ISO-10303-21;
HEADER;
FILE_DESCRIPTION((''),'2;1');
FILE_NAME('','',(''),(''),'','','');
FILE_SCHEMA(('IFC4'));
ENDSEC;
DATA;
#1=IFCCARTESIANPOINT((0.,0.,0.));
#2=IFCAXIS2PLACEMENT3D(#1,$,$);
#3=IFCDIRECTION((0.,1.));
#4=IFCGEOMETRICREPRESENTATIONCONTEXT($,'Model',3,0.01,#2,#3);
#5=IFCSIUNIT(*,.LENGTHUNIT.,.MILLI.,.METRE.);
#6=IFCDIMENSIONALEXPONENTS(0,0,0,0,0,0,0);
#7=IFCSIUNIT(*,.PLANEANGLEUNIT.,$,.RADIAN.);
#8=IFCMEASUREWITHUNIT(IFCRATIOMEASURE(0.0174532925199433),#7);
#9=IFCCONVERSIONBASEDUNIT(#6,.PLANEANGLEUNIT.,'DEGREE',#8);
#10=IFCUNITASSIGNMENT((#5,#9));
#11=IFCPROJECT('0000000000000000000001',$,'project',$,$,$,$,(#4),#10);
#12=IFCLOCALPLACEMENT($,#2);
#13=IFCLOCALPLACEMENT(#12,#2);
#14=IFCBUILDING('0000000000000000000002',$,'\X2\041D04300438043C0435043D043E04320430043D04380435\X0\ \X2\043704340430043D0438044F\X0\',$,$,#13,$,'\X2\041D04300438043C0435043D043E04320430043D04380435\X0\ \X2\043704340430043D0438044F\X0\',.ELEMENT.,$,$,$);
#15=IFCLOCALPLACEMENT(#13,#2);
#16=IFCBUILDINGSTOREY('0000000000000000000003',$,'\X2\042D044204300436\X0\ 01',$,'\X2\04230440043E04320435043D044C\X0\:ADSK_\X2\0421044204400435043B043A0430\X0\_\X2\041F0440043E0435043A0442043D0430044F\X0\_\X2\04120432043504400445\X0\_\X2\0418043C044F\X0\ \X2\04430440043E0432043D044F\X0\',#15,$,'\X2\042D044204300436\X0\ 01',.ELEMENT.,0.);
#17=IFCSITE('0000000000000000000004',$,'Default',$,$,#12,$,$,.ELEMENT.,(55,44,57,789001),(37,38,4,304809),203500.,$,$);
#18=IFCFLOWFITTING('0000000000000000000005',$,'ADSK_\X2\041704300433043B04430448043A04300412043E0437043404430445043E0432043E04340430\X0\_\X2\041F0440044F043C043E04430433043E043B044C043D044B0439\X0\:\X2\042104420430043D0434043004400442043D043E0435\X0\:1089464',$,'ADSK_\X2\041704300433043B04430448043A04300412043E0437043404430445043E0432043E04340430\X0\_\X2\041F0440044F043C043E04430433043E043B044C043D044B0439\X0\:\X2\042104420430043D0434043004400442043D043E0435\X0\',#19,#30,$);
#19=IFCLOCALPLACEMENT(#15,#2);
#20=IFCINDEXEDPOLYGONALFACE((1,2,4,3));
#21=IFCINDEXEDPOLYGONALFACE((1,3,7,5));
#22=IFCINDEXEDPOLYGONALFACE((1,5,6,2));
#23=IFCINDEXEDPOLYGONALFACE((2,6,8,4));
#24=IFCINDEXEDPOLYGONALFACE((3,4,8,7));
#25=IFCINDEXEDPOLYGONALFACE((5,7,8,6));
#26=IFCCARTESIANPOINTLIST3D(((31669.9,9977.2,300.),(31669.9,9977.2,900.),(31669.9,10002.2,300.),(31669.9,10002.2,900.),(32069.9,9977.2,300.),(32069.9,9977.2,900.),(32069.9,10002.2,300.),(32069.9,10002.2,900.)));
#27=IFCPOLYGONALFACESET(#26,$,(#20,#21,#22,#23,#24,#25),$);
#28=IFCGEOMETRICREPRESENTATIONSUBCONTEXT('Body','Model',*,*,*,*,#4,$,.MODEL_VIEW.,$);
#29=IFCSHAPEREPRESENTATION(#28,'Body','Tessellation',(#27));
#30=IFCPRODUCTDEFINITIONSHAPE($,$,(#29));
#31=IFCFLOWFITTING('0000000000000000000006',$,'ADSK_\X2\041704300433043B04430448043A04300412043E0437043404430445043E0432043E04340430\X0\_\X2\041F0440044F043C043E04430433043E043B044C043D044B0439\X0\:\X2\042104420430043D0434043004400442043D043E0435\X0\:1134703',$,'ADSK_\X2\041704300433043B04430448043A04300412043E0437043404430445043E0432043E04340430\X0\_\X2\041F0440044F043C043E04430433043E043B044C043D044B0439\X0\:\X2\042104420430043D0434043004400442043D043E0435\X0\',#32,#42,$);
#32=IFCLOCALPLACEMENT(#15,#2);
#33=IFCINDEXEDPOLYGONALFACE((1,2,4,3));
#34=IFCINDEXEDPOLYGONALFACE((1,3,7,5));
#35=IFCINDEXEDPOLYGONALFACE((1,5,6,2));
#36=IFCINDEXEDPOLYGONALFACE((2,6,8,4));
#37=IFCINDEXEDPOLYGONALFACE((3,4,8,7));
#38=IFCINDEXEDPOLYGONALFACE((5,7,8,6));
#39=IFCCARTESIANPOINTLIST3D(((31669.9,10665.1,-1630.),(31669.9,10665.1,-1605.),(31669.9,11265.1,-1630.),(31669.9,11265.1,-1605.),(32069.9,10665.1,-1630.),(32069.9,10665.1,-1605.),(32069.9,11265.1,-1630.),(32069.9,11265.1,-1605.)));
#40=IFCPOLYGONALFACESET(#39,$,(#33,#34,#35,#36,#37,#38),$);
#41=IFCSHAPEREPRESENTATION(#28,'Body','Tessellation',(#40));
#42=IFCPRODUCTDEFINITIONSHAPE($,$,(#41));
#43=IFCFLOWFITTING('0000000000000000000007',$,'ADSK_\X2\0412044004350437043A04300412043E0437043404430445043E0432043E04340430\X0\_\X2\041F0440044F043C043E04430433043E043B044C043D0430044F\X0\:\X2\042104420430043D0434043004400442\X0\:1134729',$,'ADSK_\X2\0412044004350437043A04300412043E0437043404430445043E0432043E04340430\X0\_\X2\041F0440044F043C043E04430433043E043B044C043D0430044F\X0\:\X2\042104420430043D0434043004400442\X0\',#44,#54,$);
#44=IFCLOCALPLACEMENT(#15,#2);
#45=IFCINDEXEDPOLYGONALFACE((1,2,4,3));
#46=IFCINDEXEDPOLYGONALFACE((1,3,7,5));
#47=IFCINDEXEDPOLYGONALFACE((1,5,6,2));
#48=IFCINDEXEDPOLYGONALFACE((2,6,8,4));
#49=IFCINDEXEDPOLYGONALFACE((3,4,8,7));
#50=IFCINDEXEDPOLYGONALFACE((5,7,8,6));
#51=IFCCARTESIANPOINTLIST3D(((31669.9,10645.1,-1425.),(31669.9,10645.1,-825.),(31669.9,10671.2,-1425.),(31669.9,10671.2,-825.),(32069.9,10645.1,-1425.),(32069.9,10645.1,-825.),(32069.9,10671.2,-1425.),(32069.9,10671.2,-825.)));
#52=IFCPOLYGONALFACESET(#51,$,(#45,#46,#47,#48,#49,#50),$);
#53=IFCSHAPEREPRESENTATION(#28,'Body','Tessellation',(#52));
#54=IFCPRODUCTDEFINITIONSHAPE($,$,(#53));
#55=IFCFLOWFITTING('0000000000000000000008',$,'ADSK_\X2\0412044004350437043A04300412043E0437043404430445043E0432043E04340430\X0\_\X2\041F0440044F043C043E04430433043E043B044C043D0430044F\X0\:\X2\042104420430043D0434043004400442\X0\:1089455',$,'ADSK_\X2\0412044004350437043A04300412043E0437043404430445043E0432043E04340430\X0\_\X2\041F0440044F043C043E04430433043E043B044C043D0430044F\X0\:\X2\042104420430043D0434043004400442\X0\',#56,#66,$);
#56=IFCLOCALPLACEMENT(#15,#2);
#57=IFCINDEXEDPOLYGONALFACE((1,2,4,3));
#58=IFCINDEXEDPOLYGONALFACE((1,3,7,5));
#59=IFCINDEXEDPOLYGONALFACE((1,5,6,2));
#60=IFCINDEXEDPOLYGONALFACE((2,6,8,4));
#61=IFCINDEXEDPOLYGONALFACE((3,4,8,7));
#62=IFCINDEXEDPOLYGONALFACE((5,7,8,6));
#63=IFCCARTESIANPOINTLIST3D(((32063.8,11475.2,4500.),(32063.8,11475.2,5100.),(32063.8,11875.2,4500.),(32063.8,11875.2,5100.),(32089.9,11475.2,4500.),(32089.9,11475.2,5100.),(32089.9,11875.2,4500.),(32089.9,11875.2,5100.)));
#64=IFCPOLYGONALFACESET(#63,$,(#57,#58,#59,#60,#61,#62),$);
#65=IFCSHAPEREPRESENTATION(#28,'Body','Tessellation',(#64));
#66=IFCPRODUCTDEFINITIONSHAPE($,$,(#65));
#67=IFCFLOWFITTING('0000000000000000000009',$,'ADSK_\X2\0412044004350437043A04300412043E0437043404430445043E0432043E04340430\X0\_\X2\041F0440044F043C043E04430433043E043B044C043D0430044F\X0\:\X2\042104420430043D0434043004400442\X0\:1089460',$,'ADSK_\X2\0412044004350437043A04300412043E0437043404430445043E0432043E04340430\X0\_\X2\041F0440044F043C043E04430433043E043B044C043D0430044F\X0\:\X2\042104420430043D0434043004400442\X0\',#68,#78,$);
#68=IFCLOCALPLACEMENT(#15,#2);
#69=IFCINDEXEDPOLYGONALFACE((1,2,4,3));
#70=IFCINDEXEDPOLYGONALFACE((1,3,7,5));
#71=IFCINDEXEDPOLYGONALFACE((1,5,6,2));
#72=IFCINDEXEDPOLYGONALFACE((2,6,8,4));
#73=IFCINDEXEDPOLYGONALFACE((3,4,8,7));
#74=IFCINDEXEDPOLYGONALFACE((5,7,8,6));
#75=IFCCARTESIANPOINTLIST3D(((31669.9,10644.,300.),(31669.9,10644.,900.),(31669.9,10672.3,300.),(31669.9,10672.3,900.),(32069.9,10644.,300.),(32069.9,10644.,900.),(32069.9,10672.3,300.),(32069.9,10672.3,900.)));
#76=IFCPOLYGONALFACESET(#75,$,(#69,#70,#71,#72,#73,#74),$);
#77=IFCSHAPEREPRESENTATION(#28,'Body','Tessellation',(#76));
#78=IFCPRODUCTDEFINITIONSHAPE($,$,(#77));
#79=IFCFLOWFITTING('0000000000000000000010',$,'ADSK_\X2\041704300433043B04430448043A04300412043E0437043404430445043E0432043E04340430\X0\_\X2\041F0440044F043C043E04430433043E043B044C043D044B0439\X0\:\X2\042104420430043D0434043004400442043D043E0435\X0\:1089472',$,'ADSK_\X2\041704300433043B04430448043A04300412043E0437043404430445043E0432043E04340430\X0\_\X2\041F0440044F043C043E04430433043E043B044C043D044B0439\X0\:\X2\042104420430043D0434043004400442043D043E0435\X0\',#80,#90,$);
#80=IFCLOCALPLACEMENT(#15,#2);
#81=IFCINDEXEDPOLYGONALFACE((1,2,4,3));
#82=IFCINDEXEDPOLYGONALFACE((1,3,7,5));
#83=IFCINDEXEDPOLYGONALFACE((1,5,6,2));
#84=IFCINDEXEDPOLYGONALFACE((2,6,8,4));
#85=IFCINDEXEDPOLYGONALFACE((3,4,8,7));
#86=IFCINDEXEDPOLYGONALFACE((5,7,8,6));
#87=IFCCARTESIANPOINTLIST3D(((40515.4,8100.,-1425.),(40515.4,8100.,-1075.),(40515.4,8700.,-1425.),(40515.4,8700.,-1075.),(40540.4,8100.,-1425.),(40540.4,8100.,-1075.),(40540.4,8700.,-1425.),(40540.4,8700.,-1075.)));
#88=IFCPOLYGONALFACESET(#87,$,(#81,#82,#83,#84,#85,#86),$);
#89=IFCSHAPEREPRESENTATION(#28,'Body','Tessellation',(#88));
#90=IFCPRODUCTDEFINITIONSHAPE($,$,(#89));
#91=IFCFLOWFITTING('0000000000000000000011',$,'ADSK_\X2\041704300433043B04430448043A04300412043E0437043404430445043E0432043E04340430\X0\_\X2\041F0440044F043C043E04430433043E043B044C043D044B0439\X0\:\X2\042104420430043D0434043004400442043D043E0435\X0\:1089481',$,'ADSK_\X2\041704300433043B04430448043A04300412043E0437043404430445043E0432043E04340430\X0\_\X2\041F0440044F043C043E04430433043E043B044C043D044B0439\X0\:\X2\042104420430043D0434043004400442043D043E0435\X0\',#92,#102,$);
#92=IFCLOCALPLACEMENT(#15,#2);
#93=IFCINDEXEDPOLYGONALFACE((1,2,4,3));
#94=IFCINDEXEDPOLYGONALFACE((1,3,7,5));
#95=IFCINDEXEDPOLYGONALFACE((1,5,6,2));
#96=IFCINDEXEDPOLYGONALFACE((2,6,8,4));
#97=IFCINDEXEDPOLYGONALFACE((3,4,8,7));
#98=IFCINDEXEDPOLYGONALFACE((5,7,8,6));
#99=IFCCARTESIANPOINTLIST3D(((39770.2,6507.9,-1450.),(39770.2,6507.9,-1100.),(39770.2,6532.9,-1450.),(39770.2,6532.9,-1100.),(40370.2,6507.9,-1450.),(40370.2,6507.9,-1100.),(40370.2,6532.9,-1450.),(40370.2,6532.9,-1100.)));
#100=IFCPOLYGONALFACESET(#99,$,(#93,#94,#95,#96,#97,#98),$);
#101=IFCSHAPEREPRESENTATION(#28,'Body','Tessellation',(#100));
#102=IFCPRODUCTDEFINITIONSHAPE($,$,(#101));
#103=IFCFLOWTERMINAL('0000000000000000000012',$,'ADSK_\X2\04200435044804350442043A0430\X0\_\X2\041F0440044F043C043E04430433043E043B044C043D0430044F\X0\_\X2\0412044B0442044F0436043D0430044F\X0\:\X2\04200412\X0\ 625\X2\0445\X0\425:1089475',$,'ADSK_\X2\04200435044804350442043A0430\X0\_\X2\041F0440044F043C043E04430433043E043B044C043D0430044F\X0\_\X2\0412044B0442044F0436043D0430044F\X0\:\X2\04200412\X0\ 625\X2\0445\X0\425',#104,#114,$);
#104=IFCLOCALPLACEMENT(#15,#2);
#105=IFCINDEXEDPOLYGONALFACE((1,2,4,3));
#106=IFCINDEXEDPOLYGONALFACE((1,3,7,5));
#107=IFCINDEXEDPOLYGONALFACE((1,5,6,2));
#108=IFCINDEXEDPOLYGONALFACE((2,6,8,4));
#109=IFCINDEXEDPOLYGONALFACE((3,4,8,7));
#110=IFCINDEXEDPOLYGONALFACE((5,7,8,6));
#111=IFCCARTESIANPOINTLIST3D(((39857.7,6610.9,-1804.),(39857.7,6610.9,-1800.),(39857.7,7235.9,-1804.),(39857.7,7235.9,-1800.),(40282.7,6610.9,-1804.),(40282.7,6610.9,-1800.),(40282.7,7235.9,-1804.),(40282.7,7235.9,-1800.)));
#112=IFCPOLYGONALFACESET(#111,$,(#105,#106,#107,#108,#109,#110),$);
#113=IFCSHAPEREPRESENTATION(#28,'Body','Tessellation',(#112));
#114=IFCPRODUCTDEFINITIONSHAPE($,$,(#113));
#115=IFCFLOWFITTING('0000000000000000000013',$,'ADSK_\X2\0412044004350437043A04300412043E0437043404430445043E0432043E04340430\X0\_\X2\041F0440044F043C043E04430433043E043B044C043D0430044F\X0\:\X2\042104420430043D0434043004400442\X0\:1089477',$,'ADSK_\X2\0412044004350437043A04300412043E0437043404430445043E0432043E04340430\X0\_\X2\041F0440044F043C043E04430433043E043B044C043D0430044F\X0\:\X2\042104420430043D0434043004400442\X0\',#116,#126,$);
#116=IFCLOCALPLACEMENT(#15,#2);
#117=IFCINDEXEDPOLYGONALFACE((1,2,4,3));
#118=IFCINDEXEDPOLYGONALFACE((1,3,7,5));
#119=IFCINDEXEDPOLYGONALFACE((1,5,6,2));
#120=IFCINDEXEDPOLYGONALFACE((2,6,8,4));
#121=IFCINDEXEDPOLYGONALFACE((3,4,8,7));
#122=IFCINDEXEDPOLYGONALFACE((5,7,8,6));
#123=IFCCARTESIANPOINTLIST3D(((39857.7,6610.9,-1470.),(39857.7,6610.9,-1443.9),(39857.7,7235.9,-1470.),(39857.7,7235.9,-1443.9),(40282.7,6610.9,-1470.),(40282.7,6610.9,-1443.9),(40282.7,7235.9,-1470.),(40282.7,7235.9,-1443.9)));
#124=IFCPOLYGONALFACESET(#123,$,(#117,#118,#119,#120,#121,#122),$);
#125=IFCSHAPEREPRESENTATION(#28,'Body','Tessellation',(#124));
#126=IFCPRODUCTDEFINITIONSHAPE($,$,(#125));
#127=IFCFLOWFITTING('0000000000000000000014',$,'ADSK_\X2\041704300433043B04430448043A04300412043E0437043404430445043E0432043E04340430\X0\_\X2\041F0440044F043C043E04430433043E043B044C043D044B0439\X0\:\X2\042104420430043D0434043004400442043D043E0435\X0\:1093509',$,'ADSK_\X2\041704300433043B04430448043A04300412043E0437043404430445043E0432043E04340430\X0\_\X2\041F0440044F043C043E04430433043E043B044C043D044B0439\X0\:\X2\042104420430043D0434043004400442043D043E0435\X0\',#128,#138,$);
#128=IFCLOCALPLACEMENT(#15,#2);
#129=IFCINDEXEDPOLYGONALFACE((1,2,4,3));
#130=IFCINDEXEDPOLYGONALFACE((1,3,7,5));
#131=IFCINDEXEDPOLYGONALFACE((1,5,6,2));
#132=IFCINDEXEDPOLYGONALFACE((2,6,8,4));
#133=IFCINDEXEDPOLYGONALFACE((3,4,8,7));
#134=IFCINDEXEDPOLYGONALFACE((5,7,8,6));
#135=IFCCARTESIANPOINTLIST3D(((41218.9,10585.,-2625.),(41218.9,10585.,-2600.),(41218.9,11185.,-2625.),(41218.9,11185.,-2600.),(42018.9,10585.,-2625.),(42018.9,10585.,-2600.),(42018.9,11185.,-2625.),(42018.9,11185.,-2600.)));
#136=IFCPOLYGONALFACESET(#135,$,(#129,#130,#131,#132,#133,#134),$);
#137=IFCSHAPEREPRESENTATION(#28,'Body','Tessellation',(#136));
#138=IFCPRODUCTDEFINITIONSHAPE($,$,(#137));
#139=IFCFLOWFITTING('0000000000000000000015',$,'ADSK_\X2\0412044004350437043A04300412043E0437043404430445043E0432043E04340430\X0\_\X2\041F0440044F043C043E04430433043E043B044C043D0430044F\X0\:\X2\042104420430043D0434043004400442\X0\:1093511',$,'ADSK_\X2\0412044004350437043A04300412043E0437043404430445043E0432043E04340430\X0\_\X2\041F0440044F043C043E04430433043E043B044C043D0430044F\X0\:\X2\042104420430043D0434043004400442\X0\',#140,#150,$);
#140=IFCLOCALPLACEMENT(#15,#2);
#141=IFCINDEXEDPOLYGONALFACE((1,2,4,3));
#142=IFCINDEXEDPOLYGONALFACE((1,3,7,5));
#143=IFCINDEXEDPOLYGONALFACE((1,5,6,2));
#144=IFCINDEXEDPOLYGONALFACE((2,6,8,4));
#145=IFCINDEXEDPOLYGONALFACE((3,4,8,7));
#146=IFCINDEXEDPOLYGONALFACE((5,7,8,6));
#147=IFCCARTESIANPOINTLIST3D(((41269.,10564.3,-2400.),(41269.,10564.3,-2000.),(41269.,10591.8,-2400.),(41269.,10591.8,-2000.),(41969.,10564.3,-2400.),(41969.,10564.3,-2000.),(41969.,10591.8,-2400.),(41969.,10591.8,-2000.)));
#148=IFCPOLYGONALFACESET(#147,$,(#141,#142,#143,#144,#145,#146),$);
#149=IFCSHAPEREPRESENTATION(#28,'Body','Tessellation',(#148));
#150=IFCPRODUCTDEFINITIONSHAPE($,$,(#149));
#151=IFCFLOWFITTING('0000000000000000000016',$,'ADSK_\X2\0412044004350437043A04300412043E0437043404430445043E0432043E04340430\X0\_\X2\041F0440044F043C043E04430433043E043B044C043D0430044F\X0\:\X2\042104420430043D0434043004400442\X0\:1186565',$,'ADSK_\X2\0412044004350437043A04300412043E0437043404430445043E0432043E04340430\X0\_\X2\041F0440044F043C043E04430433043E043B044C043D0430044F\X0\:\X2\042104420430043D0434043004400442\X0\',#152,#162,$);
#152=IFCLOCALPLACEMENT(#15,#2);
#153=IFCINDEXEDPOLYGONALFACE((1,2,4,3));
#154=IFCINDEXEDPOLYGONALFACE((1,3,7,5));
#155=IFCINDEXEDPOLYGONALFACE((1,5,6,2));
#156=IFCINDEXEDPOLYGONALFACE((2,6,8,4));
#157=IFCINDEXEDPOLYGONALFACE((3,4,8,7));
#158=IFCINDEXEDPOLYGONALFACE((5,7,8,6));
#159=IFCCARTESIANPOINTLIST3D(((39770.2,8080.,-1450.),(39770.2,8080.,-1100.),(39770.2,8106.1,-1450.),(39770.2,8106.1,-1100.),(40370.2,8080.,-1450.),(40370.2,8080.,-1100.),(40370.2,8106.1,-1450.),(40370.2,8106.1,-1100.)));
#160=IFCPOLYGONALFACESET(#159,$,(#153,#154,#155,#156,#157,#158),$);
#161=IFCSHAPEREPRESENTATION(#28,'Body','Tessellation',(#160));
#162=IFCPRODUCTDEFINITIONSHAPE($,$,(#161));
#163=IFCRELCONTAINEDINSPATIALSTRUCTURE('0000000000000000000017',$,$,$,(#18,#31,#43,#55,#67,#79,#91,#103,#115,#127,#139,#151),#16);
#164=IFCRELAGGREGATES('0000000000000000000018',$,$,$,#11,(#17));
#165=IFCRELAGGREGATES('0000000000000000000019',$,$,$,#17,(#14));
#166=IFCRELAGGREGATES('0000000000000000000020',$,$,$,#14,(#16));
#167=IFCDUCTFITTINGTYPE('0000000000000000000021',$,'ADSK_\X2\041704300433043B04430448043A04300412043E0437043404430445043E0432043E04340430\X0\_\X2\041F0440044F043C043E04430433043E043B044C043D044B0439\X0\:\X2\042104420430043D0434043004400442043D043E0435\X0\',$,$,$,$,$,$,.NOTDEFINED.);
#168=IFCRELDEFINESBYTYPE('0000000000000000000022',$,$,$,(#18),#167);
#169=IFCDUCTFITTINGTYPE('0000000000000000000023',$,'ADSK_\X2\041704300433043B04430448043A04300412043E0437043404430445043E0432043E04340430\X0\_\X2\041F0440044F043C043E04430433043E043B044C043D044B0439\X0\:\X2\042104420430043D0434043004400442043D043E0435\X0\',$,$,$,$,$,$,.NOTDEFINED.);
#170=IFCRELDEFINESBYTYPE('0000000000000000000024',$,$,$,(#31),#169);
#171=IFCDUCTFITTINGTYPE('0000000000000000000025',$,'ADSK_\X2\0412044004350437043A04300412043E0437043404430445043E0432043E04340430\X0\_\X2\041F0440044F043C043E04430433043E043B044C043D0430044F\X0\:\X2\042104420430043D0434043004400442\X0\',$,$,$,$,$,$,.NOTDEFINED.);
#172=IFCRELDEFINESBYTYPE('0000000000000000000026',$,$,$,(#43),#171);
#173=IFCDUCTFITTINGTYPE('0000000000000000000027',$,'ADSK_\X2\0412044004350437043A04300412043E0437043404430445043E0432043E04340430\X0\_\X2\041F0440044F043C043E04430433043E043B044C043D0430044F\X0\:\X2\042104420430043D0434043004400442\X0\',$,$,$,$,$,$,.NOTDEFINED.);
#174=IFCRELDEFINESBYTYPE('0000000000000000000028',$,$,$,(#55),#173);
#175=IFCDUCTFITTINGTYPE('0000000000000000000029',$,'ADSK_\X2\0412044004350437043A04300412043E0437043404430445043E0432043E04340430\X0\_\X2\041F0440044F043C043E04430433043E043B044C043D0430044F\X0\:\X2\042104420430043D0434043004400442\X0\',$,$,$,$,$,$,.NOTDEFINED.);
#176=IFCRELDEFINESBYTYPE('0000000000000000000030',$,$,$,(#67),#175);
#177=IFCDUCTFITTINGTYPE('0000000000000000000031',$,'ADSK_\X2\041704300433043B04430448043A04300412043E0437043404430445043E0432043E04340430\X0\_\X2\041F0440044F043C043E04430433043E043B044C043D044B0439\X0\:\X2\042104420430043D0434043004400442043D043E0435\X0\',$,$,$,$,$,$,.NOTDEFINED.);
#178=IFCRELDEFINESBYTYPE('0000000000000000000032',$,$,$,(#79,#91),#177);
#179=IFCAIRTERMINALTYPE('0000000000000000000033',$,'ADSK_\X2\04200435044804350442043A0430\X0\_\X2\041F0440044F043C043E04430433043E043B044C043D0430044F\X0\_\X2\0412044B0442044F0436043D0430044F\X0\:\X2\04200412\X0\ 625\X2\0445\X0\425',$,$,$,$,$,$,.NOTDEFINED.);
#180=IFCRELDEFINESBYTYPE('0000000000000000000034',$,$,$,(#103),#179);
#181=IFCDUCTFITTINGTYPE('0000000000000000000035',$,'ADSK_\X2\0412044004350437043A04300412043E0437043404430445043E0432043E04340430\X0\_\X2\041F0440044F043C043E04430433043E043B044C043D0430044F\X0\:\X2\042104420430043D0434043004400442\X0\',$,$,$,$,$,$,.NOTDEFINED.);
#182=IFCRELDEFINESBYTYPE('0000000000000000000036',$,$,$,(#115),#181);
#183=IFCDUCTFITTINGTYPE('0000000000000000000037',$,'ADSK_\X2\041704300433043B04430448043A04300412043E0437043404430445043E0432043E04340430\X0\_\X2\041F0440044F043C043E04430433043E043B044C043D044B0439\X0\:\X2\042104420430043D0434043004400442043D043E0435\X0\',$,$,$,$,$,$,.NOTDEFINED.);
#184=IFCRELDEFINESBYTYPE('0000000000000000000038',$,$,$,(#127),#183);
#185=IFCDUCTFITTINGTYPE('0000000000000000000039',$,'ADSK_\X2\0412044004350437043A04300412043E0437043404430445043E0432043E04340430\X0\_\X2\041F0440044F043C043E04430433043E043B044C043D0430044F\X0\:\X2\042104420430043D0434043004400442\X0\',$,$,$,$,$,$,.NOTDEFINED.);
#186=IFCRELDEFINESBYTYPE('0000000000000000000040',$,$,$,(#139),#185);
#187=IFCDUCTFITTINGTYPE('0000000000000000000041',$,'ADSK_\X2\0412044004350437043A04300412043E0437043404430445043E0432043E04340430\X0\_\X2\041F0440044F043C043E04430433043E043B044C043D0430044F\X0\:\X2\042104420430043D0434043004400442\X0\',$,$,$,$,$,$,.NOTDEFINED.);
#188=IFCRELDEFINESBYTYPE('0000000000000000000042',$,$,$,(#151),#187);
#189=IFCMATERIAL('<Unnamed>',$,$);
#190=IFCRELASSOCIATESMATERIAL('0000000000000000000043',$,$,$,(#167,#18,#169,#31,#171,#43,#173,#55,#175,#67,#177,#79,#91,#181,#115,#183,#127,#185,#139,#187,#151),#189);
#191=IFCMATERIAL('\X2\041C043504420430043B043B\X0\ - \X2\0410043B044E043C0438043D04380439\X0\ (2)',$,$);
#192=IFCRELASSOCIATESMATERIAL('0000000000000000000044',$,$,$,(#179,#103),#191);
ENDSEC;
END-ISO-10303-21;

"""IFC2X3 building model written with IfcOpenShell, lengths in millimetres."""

from ifc_helpers import new_model, entity, si_unit, converted_unit, direction, frame, origin, origin_2d_with_axis, place, context, subcontext, project, spatial, rectangle, extrude, source, transform, mapped, material, type_object, type_shapes, element, save


model = new_model("IFC2X3")

# Units and contexts
model_context = context("Model", 3, precision=0.01, world=origin(), true_north=direction((0.0, 1.0)))
body_context = subcontext(model_context, "Body", "Model", "MODEL_VIEW")
ifc_project = project(units=[si_unit("LENGTHUNIT", "METRE", prefix="MILLI"), converted_unit("PLANEANGLEUNIT", "DEGREE", entity("IfcRatioMeasure", 0.0174532925199433), si_unit("PLANEANGLEUNIT", "RADIAN"), dimensions=[0, 0, 0, 0, 0, 0, 0])], contexts=[model_context])

# Site, building, storey
site_placement = place(None, origin())
site = spatial("IfcSite", under=ifc_project, at=site_placement, Name="Default", CompositionType="ELEMENT", RefLatitude=(55, 44, 57, 789001), RefLongitude=(37, 38, 4, 304809), RefElevation=203500.0)
building_placement = place(site_placement, origin())
building = spatial("IfcBuilding", under=site, at=building_placement, Name="Наименование здания", LongName="Наименование здания", CompositionType="ELEMENT")
storey_placement = place(building_placement, origin())
storey = spatial("IfcBuildingStorey", under=building, at=storey_placement, Name="Этаж 01", ObjectType="Уровень:ADSK_Стрелка_Проектная_Вверх_Имя уровня", LongName="Этаж 01", CompositionType="ELEMENT", Elevation=0.0)

# Flow fittings
ifc_material_1 = material(Name="<Unnamed>")
duct_fitting_type_1 = type_object("IfcDuctFittingType", Name="ADSK_ЗаглушкаВоздуховода_Прямоугольный:Стандартное", PredefinedType="NOTDEFINED", material=ifc_material_1)
shared_shape_1 = source(origin(), body_context, "Body", "SweptSolid", [
    extrude(rectangle(XDim=25.0, YDim=400.0, at=origin_2d_with_axis()), frame((12.5, 0.0, -300.0)), (0.0, 0.0, 1.0), 600.0),
])
type_shapes(duct_fitting_type_1, [shared_shape_1])
for number, where, z_axis, x_axis, name in (
    (1, (31869.9, 10002.2, 600.0), (0.0, 0.0, 1.0), (0.0, -1.0, 0.0), "ADSK_ЗаглушкаВоздуховода_Прямоугольный:Стандартное:1089464"),
):
    element("IfcFlowFitting", number, at=place(storey_placement, frame(where, z_axis=z_axis, x_axis=x_axis)), inside=storey, type_object=duct_fitting_type_1, material=ifc_material_1, Name=name, ObjectType="ADSK_ЗаглушкаВоздуховода_Прямоугольный:Стандартное", context=body_context, shape_type="MappedRepresentation", body=[
        mapped(shared_shape_1, transform((0.0, 0.0, 0.0), scale=1.0)),
    ])
duct_fitting_type_2 = type_object("IfcDuctFittingType", Name="ADSK_ЗаглушкаВоздуховода_Прямоугольный:Стандартное", PredefinedType="NOTDEFINED", material=ifc_material_1)
shared_shape_2 = source(origin(), body_context, "Body", "SweptSolid", [
    extrude(rectangle(XDim=25.0, YDim=600.0, at=origin_2d_with_axis()), frame((12.5, 0.0, -200.0)), (0.0, 0.0, 1.0), 400.0),
])
type_shapes(duct_fitting_type_2, [shared_shape_2])
flow_fitting_1_placement = place(storey_placement, frame((31869.9, 10965.1, -1605.0), z_axis=(1.0, 0.0, 0.0), x_axis=(0.0, 0.0, -1.0)))
element("IfcFlowFitting", 2, at=flow_fitting_1_placement, inside=storey, type_object=duct_fitting_type_2, material=ifc_material_1, Name="ADSK_ЗаглушкаВоздуховода_Прямоугольный:Стандартное:1134703", ObjectType="ADSK_ЗаглушкаВоздуховода_Прямоугольный:Стандартное", context=body_context, shape_type="MappedRepresentation", body=[
    mapped(shared_shape_2, transform((0.0, 0.0, 0.0), scale=1.0)),
])
duct_fitting_type_3 = type_object("IfcDuctFittingType", Name="ADSK_ВрезкаВоздуховода_Прямоугольная:Стандарт", PredefinedType="NOTDEFINED", material=ifc_material_1)
shared_shape_3 = source(origin(), body_context, "Body", "SweptSolid", [
    extrude(rectangle(XDim=600.0, YDim=26.1, at=origin_2d_with_axis()), frame((7.0, 0.0, -200.0), z_axis=(0.0, 0.0, 1.0), x_axis=(0.0, -1.0, 0.0)), (0.0, 0.0, 1.0), 400.0),
])
type_shapes(duct_fitting_type_3, [shared_shape_3])
flow_fitting_2_placement = place(storey_placement, frame((31869.9, 10665.1, -1125.0), z_axis=(-1.0, 0.0, 0.0), x_axis=(0.0, -1.0, 0.0)))
element("IfcFlowFitting", 3, at=flow_fitting_2_placement, inside=storey, type_object=duct_fitting_type_3, material=ifc_material_1, Name="ADSK_ВрезкаВоздуховода_Прямоугольная:Стандарт:1134729", ObjectType="ADSK_ВрезкаВоздуховода_Прямоугольная:Стандарт", context=body_context, shape_type="MappedRepresentation", body=[
    mapped(shared_shape_3, transform((0.0, 0.0, 0.0), scale=1.0)),
])
duct_fitting_type_4 = type_object("IfcDuctFittingType", Name="ADSK_ВрезкаВоздуховода_Прямоугольная:Стандарт", PredefinedType="NOTDEFINED", material=ifc_material_1)
shared_shape_4 = source(origin(), body_context, "Body", "SweptSolid", [
    extrude(rectangle(XDim=26.1, YDim=400.0, at=origin_2d_with_axis()), frame((7.0, 0.0, -300.0)), (0.0, 0.0, 1.0), 600.0),
])
type_shapes(duct_fitting_type_4, [shared_shape_4])
flow_fitting_3_placement = place(storey_placement, frame((32069.9, 11675.2, 4800.0), z_axis=(0.0, 0.0, -1.0), x_axis=(1.0, 0.0, 0.0)))
element("IfcFlowFitting", 4, at=flow_fitting_3_placement, inside=storey, type_object=duct_fitting_type_4, material=ifc_material_1, Name="ADSK_ВрезкаВоздуховода_Прямоугольная:Стандарт:1089455", ObjectType="ADSK_ВрезкаВоздуховода_Прямоугольная:Стандарт", context=body_context, shape_type="MappedRepresentation", body=[
    mapped(shared_shape_4, transform((0.0, 0.0, 0.0), scale=1.0)),
])
duct_fitting_type_5 = type_object("IfcDuctFittingType", Name="ADSK_ВрезкаВоздуховода_Прямоугольная:Стандарт", PredefinedType="NOTDEFINED", material=ifc_material_1)
shared_shape_5 = source(origin(), body_context, "Body", "SweptSolid", [
    extrude(rectangle(XDim=28.2, YDim=600.0, at=origin_2d_with_axis()), frame((7.0, 0.0, -200.0)), (0.0, 0.0, 1.0), 400.0),
])
type_shapes(duct_fitting_type_5, [shared_shape_5])
flow_fitting_4_placement = place(storey_placement, frame((31869.9, 10665.1, 600.0), z_axis=(-1.0, 0.0, 0.0), x_axis=(0.0, -1.0, 0.0)))
element("IfcFlowFitting", 5, at=flow_fitting_4_placement, inside=storey, type_object=duct_fitting_type_5, material=ifc_material_1, Name="ADSK_ВрезкаВоздуховода_Прямоугольная:Стандарт:1089460", ObjectType="ADSK_ВрезкаВоздуховода_Прямоугольная:Стандарт", context=body_context, shape_type="MappedRepresentation", body=[
    mapped(shared_shape_5, transform((0.0, 0.0, 0.0), scale=1.0)),
])
duct_fitting_type_6 = type_object("IfcDuctFittingType", Name="ADSK_ЗаглушкаВоздуховода_Прямоугольный:Стандартное", PredefinedType="NOTDEFINED", material=ifc_material_1)
shared_shape_6 = source(origin(), body_context, "Body", "SweptSolid", [
    extrude(rectangle(XDim=25.0, YDim=600.0, at=origin_2d_with_axis()), frame((12.5, 0.0, -175.0)), (0.0, 0.0, 1.0), 350.0),
])
type_shapes(duct_fitting_type_6, [shared_shape_6])
flow_fitting_5_placement = place(storey_placement, frame((40515.4, 8400.0, -1250.0)))
element("IfcFlowFitting", 6, at=flow_fitting_5_placement, inside=storey, type_object=duct_fitting_type_6, material=ifc_material_1, Name="ADSK_ЗаглушкаВоздуховода_Прямоугольный:Стандартное:1089472", ObjectType="ADSK_ЗаглушкаВоздуховода_Прямоугольный:Стандартное", context=body_context, shape_type="MappedRepresentation", body=[
    mapped(shared_shape_6, transform((0.0, 0.0, 0.0), scale=1.0)),
])
flow_fitting_6_placement = place(storey_placement, frame((40070.2, 6532.9, -1275.0), z_axis=(0.0, 0.0, 1.0), x_axis=(0.0, -1.0, 0.0)))
element("IfcFlowFitting", 7, at=flow_fitting_6_placement, inside=storey, type_object=duct_fitting_type_6, material=ifc_material_1, Name="ADSK_ЗаглушкаВоздуховода_Прямоугольный:Стандартное:1089481", ObjectType="ADSK_ЗаглушкаВоздуховода_Прямоугольный:Стандартное", context=body_context, shape_type="MappedRepresentation", body=[
    mapped(shared_shape_6, transform((0.0, 0.0, 0.0), scale=1.0)),
])

# Flow terminal
ifc_material_2 = material(Name="Металл - Алюминий (2)")
air_terminal_type = type_object("IfcAirTerminalType", Name="ADSK_Решетка_Прямоугольная_Вытяжная:РВ 625х425", PredefinedType="NOTDEFINED", material=ifc_material_2)
shared_shape_7 = source(origin(), body_context, "Body", "SweptSolid", [
    extrude(rectangle(XDim=4.0, YDim=625.0, at=origin_2d_with_axis()), frame((0.0, -2.0, -212.5), z_axis=(0.0, 0.0, 1.0), x_axis=(0.0, 1.0, 0.0)), (0.0, 0.0, 1.0), 425.0),
])
type_shapes(air_terminal_type, [shared_shape_7])
flow_terminal_placement = place(storey_placement, frame((40070.2, 6923.4, -1800.0), z_axis=(1.0, 0.0, 0.0), x_axis=(0.0, 1.0, 0.0)))
element("IfcFlowTerminal", 8, at=flow_terminal_placement, inside=storey, type_object=air_terminal_type, material=ifc_material_2, Name="ADSK_Решетка_Прямоугольная_Вытяжная:РВ 625х425:1089475", ObjectType="ADSK_Решетка_Прямоугольная_Вытяжная:РВ 625х425", context=body_context, shape_type="MappedRepresentation", body=[
    mapped(shared_shape_7, transform((0.0, 0.0, 0.0), scale=1.0)),
])

# Flow fittings
duct_fitting_type_7 = type_object("IfcDuctFittingType", Name="ADSK_ВрезкаВоздуховода_Прямоугольная:Стандарт", PredefinedType="NOTDEFINED", material=ifc_material_1)
shared_shape_8 = source(origin(), body_context, "Body", "SweptSolid", [
    extrude(rectangle(XDim=425.0, YDim=26.1, at=origin_2d_with_axis()), frame((7.0, 0.0, -312.5), z_axis=(0.0, 0.0, 1.0), x_axis=(0.0, -1.0, 0.0)), (0.0, 0.0, 1.0), 625.0),
])
type_shapes(duct_fitting_type_7, [shared_shape_8])
flow_fitting_7_placement = place(storey_placement, frame((40070.2, 6923.4, -1450.0), z_axis=(0.0, -1.0, 0.0), x_axis=(0.0, 0.0, -1.0)))
element("IfcFlowFitting", 9, at=flow_fitting_7_placement, inside=storey, type_object=duct_fitting_type_7, material=ifc_material_1, Name="ADSK_ВрезкаВоздуховода_Прямоугольная:Стандарт:1089477", ObjectType="ADSK_ВрезкаВоздуховода_Прямоугольная:Стандарт", context=body_context, shape_type="MappedRepresentation", body=[
    mapped(shared_shape_8, transform((0.0, 0.0, 0.0), scale=1.0)),
])
duct_fitting_type_8 = type_object("IfcDuctFittingType", Name="ADSK_ЗаглушкаВоздуховода_Прямоугольный:Стандартное", PredefinedType="NOTDEFINED", material=ifc_material_1)
shared_shape_9 = source(origin(), body_context, "Body", "SweptSolid", [
    extrude(rectangle(XDim=25.0, YDim=600.0, at=origin_2d_with_axis()), frame((12.5, 0.0, -400.0)), (0.0, 0.0, 1.0), 800.0),
])
type_shapes(duct_fitting_type_8, [shared_shape_9])
flow_fitting_8_placement = place(storey_placement, frame((41618.9, 10885.0, -2600.0), z_axis=(1.0, 0.0, 0.0), x_axis=(0.0, 0.0, -1.0)))
element("IfcFlowFitting", 10, at=flow_fitting_8_placement, inside=storey, type_object=duct_fitting_type_8, material=ifc_material_1, Name="ADSK_ЗаглушкаВоздуховода_Прямоугольный:Стандартное:1093509", ObjectType="ADSK_ЗаглушкаВоздуховода_Прямоугольный:Стандартное", context=body_context, shape_type="MappedRepresentation", body=[
    mapped(shared_shape_9, transform((0.0, 0.0, 0.0), scale=1.0)),
])
duct_fitting_type_9 = type_object("IfcDuctFittingType", Name="ADSK_ВрезкаВоздуховода_Прямоугольная:Стандарт", PredefinedType="NOTDEFINED", material=ifc_material_1)
shared_shape_10 = source(origin(), body_context, "Body", "SweptSolid", [
    extrude(rectangle(XDim=27.5, YDim=400.0, at=origin_2d_with_axis()), frame((7.0, 0.0, -350.0)), (0.0, 0.0, 1.0), 700.0),
])
type_shapes(duct_fitting_type_9, [shared_shape_10])
flow_fitting_9_placement = place(storey_placement, frame((41619.0, 10585.0, -2200.0), z_axis=(-1.0, 0.0, 0.0), x_axis=(0.0, -1.0, 0.0)))
element("IfcFlowFitting", 11, at=flow_fitting_9_placement, inside=storey, type_object=duct_fitting_type_9, material=ifc_material_1, Name="ADSK_ВрезкаВоздуховода_Прямоугольная:Стандарт:1093511", ObjectType="ADSK_ВрезкаВоздуховода_Прямоугольная:Стандарт", context=body_context, shape_type="MappedRepresentation", body=[
    mapped(shared_shape_10, transform((0.0, 0.0, 0.0), scale=1.0)),
])
duct_fitting_type_10 = type_object("IfcDuctFittingType", Name="ADSK_ВрезкаВоздуховода_Прямоугольная:Стандарт", PredefinedType="NOTDEFINED", material=ifc_material_1)
shared_shape_11 = source(origin(), body_context, "Body", "SweptSolid", [
    extrude(rectangle(XDim=26.1, YDim=600.0, at=origin_2d_with_axis()), frame((7.0, 0.0, -175.0)), (0.0, 0.0, 1.0), 350.0),
])
type_shapes(duct_fitting_type_10, [shared_shape_11])
flow_fitting_10_placement = place(storey_placement, frame((40070.2, 8100.0, -1275.0), z_axis=(0.0, 0.0, -1.0), x_axis=(0.0, -1.0, 0.0)))
element("IfcFlowFitting", 12, at=flow_fitting_10_placement, inside=storey, type_object=duct_fitting_type_10, material=ifc_material_1, Name="ADSK_ВрезкаВоздуховода_Прямоугольная:Стандарт:1186565", ObjectType="ADSK_ВрезкаВоздуховода_Прямоугольная:Стандарт", context=body_context, shape_type="MappedRepresentation", body=[
    mapped(shared_shape_11, transform((0.0, 0.0, 0.0), scale=1.0)),
])

save(model, "model.ifc")
